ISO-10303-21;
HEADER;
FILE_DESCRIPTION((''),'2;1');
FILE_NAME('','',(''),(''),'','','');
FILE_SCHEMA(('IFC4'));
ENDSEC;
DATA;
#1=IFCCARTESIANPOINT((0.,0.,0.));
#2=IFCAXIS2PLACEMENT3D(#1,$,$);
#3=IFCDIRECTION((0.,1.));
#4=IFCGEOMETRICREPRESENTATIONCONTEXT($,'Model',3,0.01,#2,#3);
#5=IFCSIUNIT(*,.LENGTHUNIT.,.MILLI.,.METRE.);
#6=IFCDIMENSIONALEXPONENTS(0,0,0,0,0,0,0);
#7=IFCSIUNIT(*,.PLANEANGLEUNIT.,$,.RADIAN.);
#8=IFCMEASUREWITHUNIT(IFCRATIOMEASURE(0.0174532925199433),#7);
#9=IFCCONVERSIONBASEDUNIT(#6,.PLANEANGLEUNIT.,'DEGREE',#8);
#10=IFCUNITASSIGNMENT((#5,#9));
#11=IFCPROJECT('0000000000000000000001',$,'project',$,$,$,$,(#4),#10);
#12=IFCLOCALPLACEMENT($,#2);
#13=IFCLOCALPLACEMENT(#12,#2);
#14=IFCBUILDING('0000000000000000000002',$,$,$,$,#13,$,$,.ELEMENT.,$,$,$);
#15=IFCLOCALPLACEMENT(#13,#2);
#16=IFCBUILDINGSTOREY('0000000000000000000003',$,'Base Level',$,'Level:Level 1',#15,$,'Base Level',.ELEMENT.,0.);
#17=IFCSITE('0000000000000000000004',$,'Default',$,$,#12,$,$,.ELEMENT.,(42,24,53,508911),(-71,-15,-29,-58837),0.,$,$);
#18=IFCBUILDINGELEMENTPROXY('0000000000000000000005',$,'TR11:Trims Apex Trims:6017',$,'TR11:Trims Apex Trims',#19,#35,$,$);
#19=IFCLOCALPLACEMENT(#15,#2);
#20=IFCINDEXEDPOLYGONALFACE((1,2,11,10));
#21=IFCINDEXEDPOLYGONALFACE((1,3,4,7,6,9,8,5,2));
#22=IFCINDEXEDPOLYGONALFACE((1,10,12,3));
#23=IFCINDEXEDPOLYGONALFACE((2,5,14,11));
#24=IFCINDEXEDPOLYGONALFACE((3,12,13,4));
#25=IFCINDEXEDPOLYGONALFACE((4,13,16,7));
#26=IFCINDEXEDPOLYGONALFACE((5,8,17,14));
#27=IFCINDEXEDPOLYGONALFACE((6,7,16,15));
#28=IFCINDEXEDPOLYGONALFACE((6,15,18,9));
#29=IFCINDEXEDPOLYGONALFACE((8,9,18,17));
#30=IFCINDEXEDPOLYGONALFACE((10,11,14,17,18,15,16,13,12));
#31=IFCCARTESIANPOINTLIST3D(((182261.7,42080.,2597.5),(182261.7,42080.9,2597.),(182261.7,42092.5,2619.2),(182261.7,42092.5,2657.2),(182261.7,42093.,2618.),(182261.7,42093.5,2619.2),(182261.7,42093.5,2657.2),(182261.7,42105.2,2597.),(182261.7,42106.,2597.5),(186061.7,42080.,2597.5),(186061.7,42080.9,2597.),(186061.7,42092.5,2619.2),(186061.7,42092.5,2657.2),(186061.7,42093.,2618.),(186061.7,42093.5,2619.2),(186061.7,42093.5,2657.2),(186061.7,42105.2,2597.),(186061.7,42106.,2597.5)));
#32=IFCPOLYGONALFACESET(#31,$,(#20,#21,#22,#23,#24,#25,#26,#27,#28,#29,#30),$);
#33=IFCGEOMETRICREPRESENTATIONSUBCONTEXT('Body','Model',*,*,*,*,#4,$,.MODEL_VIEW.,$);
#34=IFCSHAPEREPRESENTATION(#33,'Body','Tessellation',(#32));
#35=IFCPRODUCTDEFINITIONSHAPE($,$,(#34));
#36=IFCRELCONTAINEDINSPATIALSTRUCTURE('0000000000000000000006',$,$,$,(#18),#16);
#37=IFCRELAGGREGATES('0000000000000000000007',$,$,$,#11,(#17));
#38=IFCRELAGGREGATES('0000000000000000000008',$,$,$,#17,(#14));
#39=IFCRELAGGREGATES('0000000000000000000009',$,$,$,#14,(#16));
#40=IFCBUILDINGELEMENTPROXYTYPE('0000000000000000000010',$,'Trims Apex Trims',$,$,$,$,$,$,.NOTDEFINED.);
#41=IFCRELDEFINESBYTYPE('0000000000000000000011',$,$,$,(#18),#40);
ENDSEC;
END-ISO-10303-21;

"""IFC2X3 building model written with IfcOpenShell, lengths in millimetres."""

from ifc_helpers import new_model, entity, si_unit, converted_unit, direction, frame, origin, place, context, subcontext, project, spatial, polyline, outline, extrude, source, transform, mapped, type_object, type_shapes, element, save


model = new_model("IFC2X3")

# Units and contexts
model_context = context("Model", 3, precision=0.01, world=origin(), true_north=direction((0.0, 1.0)))
body_context = subcontext(model_context, "Body", "Model", "MODEL_VIEW")
ifc_project = project(units=[si_unit("LENGTHUNIT", "METRE", prefix="MILLI"), converted_unit("PLANEANGLEUNIT", "DEGREE", entity("IfcRatioMeasure", 0.0174532925199433), si_unit("PLANEANGLEUNIT", "RADIAN"), dimensions=[0, 0, 0, 0, 0, 0, 0])], contexts=[model_context])

# Site, building, storey
site_placement = place(None, origin())
site = spatial("IfcSite", under=ifc_project, at=site_placement, Name="Default", CompositionType="ELEMENT", RefLatitude=(42, 24, 53, 508911), RefLongitude=(-71, -15, -29, -58837), RefElevation=0.0)
building_placement = place(site_placement, origin())
building = spatial("IfcBuilding", under=site, at=building_placement, CompositionType="ELEMENT")
storey_placement = place(building_placement, origin())
storey = spatial("IfcBuildingStorey", under=building, at=storey_placement, Name="Base Level", ObjectType="Level:Level 1", LongName="Base Level", CompositionType="ELEMENT", Elevation=0.0)

# Building element proxy
building_element_proxy_type_1 = type_object("IfcBuildingElementProxyType", Name="Trims Apex Trims", PredefinedType="NOTDEFINED")
shared_shape_1 = source(origin(), body_context, "Body", "SweptSolid", [
    extrude(outline(polyline([(-0.5, -39.4), (0.5, -39.4), (0.5, -1.4), (13.0, 20.2), (12.1, 20.7), (0.0, -0.3), (-12.1, 20.7), (-13.0, 20.2), (-0.5, -1.4), (-0.5, -39.4)])), frame((0.0, 0.0, -1.3), z_axis=(1.0, 0.0, 0.0), x_axis=(0.0, -1.0, 0.0)), (0.0, 0.0, 1.0), 3800.0),
])
type_shapes(building_element_proxy_type_1, [shared_shape_1])
proxy_1_placement = place(building_placement, frame((182261.7, 42093.0, 2619.0)))
element("IfcBuildingElementProxy", 1, at=proxy_1_placement, inside=storey, type_object=building_element_proxy_type_1, Name="TR11:Trims Apex Trims:6017", ObjectType="TR11:Trims Apex Trims", context=body_context, shape_type="MappedRepresentation", body=[
    mapped(shared_shape_1, transform((0.0, 0.0, 0.0), scale=1.0)),
])

save(model, "model.ifc")
